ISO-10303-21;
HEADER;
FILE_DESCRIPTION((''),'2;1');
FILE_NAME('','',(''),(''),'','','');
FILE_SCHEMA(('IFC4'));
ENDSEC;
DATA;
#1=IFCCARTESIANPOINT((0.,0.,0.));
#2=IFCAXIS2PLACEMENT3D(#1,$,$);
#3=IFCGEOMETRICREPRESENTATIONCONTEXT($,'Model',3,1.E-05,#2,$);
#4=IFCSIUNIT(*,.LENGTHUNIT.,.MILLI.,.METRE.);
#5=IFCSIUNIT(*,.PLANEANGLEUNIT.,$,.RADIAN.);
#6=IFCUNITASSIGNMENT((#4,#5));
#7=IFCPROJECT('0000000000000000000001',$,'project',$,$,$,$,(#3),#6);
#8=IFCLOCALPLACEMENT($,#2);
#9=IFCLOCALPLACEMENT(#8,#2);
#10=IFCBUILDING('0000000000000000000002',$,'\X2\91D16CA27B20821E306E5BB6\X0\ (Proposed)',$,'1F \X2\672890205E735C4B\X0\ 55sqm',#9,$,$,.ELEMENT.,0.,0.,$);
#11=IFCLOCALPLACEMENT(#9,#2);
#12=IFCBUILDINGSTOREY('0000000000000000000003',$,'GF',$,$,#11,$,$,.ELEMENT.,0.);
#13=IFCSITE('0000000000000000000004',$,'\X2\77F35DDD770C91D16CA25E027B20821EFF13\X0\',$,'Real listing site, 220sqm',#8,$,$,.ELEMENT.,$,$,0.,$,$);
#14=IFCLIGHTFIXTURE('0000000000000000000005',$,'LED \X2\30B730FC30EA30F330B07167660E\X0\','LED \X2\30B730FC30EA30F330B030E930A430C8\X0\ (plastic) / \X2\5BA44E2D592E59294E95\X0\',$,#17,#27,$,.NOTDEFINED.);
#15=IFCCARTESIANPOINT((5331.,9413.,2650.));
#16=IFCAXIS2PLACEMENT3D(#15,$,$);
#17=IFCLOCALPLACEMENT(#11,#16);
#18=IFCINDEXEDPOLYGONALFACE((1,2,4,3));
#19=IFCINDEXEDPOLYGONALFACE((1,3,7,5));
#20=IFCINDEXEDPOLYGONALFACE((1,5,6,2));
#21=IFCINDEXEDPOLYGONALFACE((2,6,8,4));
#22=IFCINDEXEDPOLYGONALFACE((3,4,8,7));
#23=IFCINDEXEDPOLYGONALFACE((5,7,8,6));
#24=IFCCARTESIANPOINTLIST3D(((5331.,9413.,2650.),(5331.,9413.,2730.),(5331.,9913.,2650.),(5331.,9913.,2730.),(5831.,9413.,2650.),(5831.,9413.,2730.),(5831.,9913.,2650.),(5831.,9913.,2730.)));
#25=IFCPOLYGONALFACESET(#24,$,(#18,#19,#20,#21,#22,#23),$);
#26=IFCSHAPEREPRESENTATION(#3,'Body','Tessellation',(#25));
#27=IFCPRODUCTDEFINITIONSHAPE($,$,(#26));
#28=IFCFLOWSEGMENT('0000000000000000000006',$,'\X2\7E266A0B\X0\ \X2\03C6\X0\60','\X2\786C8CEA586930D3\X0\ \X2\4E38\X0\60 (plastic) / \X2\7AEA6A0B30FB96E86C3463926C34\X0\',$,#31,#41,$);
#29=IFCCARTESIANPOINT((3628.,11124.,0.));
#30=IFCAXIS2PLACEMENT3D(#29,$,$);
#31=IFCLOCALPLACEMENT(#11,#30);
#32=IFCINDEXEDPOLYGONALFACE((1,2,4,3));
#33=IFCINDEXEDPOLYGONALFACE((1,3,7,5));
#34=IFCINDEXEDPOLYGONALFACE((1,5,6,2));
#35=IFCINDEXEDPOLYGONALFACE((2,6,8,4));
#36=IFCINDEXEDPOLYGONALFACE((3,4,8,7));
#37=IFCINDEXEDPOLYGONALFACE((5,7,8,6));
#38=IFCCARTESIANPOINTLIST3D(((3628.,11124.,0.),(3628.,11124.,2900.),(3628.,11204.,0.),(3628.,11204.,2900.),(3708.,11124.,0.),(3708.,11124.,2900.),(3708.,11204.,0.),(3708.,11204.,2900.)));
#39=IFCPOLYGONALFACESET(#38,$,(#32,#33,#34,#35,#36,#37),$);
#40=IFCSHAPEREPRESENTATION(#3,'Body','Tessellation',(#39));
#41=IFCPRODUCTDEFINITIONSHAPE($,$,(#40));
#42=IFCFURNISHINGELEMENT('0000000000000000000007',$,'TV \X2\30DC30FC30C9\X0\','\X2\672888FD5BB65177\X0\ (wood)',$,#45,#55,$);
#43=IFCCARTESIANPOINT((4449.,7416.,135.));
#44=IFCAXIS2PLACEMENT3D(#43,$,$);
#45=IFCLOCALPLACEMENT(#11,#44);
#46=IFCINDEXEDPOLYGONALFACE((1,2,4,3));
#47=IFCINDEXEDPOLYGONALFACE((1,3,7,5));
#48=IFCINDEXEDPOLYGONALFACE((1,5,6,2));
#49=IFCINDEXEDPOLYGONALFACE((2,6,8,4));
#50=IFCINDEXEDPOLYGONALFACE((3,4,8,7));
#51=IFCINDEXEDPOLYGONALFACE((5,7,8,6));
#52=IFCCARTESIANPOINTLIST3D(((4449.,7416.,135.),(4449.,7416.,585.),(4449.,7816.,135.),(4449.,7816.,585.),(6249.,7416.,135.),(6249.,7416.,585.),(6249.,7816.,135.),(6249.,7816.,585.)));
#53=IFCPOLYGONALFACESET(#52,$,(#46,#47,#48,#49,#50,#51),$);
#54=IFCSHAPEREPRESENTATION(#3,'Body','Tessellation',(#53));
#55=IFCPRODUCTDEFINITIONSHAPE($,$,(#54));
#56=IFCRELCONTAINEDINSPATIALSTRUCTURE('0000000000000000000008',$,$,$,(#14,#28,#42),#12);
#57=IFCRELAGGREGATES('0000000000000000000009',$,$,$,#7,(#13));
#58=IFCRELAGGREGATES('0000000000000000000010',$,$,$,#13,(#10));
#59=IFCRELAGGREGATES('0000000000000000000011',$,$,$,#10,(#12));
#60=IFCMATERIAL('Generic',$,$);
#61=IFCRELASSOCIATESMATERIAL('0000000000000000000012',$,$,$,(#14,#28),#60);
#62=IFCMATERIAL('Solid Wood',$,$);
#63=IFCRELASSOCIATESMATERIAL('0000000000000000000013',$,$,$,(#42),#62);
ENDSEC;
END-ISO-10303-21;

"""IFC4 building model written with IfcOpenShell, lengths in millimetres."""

from ifc_helpers import new_model, si_unit, frame, frame_2d, origin, place, context, project, spatial, rectangle, extrude, material, element, save


model = new_model("IFC4")

# Units and contexts
model_context = context("Model", 3, precision=1e-05, world=origin())
ifc_project = project(units=[si_unit("LENGTHUNIT", "METRE", prefix="MILLI"), si_unit("PLANEANGLEUNIT", "RADIAN")], contexts=[model_context])

# Site, building, storey
site_placement = place(None, origin())
site = spatial("IfcSite", under=ifc_project, at=site_placement, Name="石川県金沢市笠舞３", ObjectType="Real listing site, 220sqm", CompositionType="ELEMENT", RefElevation=0.0)
building_placement = place(site_placement, origin())
building = spatial("IfcBuilding", under=site, at=building_placement, Name="金沢笠舞の家 (Proposed)", ObjectType="1F 木造平屋 55sqm", CompositionType="ELEMENT", ElevationOfRefHeight=0.0, ElevationOfTerrain=0.0)
storey_placement = place(building_placement, origin())
storey = spatial("IfcBuildingStorey", under=building, at=storey_placement, Name="GF", CompositionType="ELEMENT", Elevation=0.0)

# Shared definitions
ifc_material_1 = material(Name="Solid Wood")

# Shared definitions
ifc_material_2 = material(Name="Generic")

# Light fixture
light_fixture_placement = place(storey_placement, frame((5331.0, 9413.0, 2650.0)))
element("IfcLightFixture", 1, at=light_fixture_placement, inside=storey, material=ifc_material_2, Name="LED シーリング照明", Description="LED シーリングライト (plastic) / 室中央天井", PredefinedType="NOTDEFINED", context=model_context, shape_type="SweptSolid", body=[
    extrude(rectangle(XDim=500.0, YDim=500.0, at=frame_2d((250.0, 250.0))), frame((5331.0, 9413.0, 2650.0)), (0.0, 0.0, 1.0), 80.0),
])

# Flow segment
flow_segment_1_placement = place(storey_placement, frame((3628.0, 11124.0, 0.0)))
element("IfcFlowSegment", 2, at=flow_segment_1_placement, inside=storey, material=ifc_material_2, Name="縦樋 φ60", Description="硬質塩ビ 丸60 (plastic) / 竪樋・雨水排水", context=model_context, shape_type="SweptSolid", body=[
    extrude(rectangle(XDim=80.0, YDim=80.0, at=frame_2d((40.0, 40.0))), frame((3628.0, 11124.0, 0.0)), (0.0, 0.0, 1.0), 2900.0),
])

# Furnishing element
furnishing_placement = place(storey_placement, frame((4449.0, 7416.0, 135.0)))
element("IfcFurnishingElement", 3, at=furnishing_placement, inside=storey, material=ifc_material_1, Name="TV ボード", Description="木製家具 (wood)", context=model_context, shape_type="SweptSolid", body=[
    extrude(rectangle(XDim=1800.0, YDim=400.0, at=frame_2d((900.0, 200.0))), frame((4449.0, 7416.0, 135.0)), (0.0, 0.0, 1.0), 450.0),
])

save(model, "model.ifc")
